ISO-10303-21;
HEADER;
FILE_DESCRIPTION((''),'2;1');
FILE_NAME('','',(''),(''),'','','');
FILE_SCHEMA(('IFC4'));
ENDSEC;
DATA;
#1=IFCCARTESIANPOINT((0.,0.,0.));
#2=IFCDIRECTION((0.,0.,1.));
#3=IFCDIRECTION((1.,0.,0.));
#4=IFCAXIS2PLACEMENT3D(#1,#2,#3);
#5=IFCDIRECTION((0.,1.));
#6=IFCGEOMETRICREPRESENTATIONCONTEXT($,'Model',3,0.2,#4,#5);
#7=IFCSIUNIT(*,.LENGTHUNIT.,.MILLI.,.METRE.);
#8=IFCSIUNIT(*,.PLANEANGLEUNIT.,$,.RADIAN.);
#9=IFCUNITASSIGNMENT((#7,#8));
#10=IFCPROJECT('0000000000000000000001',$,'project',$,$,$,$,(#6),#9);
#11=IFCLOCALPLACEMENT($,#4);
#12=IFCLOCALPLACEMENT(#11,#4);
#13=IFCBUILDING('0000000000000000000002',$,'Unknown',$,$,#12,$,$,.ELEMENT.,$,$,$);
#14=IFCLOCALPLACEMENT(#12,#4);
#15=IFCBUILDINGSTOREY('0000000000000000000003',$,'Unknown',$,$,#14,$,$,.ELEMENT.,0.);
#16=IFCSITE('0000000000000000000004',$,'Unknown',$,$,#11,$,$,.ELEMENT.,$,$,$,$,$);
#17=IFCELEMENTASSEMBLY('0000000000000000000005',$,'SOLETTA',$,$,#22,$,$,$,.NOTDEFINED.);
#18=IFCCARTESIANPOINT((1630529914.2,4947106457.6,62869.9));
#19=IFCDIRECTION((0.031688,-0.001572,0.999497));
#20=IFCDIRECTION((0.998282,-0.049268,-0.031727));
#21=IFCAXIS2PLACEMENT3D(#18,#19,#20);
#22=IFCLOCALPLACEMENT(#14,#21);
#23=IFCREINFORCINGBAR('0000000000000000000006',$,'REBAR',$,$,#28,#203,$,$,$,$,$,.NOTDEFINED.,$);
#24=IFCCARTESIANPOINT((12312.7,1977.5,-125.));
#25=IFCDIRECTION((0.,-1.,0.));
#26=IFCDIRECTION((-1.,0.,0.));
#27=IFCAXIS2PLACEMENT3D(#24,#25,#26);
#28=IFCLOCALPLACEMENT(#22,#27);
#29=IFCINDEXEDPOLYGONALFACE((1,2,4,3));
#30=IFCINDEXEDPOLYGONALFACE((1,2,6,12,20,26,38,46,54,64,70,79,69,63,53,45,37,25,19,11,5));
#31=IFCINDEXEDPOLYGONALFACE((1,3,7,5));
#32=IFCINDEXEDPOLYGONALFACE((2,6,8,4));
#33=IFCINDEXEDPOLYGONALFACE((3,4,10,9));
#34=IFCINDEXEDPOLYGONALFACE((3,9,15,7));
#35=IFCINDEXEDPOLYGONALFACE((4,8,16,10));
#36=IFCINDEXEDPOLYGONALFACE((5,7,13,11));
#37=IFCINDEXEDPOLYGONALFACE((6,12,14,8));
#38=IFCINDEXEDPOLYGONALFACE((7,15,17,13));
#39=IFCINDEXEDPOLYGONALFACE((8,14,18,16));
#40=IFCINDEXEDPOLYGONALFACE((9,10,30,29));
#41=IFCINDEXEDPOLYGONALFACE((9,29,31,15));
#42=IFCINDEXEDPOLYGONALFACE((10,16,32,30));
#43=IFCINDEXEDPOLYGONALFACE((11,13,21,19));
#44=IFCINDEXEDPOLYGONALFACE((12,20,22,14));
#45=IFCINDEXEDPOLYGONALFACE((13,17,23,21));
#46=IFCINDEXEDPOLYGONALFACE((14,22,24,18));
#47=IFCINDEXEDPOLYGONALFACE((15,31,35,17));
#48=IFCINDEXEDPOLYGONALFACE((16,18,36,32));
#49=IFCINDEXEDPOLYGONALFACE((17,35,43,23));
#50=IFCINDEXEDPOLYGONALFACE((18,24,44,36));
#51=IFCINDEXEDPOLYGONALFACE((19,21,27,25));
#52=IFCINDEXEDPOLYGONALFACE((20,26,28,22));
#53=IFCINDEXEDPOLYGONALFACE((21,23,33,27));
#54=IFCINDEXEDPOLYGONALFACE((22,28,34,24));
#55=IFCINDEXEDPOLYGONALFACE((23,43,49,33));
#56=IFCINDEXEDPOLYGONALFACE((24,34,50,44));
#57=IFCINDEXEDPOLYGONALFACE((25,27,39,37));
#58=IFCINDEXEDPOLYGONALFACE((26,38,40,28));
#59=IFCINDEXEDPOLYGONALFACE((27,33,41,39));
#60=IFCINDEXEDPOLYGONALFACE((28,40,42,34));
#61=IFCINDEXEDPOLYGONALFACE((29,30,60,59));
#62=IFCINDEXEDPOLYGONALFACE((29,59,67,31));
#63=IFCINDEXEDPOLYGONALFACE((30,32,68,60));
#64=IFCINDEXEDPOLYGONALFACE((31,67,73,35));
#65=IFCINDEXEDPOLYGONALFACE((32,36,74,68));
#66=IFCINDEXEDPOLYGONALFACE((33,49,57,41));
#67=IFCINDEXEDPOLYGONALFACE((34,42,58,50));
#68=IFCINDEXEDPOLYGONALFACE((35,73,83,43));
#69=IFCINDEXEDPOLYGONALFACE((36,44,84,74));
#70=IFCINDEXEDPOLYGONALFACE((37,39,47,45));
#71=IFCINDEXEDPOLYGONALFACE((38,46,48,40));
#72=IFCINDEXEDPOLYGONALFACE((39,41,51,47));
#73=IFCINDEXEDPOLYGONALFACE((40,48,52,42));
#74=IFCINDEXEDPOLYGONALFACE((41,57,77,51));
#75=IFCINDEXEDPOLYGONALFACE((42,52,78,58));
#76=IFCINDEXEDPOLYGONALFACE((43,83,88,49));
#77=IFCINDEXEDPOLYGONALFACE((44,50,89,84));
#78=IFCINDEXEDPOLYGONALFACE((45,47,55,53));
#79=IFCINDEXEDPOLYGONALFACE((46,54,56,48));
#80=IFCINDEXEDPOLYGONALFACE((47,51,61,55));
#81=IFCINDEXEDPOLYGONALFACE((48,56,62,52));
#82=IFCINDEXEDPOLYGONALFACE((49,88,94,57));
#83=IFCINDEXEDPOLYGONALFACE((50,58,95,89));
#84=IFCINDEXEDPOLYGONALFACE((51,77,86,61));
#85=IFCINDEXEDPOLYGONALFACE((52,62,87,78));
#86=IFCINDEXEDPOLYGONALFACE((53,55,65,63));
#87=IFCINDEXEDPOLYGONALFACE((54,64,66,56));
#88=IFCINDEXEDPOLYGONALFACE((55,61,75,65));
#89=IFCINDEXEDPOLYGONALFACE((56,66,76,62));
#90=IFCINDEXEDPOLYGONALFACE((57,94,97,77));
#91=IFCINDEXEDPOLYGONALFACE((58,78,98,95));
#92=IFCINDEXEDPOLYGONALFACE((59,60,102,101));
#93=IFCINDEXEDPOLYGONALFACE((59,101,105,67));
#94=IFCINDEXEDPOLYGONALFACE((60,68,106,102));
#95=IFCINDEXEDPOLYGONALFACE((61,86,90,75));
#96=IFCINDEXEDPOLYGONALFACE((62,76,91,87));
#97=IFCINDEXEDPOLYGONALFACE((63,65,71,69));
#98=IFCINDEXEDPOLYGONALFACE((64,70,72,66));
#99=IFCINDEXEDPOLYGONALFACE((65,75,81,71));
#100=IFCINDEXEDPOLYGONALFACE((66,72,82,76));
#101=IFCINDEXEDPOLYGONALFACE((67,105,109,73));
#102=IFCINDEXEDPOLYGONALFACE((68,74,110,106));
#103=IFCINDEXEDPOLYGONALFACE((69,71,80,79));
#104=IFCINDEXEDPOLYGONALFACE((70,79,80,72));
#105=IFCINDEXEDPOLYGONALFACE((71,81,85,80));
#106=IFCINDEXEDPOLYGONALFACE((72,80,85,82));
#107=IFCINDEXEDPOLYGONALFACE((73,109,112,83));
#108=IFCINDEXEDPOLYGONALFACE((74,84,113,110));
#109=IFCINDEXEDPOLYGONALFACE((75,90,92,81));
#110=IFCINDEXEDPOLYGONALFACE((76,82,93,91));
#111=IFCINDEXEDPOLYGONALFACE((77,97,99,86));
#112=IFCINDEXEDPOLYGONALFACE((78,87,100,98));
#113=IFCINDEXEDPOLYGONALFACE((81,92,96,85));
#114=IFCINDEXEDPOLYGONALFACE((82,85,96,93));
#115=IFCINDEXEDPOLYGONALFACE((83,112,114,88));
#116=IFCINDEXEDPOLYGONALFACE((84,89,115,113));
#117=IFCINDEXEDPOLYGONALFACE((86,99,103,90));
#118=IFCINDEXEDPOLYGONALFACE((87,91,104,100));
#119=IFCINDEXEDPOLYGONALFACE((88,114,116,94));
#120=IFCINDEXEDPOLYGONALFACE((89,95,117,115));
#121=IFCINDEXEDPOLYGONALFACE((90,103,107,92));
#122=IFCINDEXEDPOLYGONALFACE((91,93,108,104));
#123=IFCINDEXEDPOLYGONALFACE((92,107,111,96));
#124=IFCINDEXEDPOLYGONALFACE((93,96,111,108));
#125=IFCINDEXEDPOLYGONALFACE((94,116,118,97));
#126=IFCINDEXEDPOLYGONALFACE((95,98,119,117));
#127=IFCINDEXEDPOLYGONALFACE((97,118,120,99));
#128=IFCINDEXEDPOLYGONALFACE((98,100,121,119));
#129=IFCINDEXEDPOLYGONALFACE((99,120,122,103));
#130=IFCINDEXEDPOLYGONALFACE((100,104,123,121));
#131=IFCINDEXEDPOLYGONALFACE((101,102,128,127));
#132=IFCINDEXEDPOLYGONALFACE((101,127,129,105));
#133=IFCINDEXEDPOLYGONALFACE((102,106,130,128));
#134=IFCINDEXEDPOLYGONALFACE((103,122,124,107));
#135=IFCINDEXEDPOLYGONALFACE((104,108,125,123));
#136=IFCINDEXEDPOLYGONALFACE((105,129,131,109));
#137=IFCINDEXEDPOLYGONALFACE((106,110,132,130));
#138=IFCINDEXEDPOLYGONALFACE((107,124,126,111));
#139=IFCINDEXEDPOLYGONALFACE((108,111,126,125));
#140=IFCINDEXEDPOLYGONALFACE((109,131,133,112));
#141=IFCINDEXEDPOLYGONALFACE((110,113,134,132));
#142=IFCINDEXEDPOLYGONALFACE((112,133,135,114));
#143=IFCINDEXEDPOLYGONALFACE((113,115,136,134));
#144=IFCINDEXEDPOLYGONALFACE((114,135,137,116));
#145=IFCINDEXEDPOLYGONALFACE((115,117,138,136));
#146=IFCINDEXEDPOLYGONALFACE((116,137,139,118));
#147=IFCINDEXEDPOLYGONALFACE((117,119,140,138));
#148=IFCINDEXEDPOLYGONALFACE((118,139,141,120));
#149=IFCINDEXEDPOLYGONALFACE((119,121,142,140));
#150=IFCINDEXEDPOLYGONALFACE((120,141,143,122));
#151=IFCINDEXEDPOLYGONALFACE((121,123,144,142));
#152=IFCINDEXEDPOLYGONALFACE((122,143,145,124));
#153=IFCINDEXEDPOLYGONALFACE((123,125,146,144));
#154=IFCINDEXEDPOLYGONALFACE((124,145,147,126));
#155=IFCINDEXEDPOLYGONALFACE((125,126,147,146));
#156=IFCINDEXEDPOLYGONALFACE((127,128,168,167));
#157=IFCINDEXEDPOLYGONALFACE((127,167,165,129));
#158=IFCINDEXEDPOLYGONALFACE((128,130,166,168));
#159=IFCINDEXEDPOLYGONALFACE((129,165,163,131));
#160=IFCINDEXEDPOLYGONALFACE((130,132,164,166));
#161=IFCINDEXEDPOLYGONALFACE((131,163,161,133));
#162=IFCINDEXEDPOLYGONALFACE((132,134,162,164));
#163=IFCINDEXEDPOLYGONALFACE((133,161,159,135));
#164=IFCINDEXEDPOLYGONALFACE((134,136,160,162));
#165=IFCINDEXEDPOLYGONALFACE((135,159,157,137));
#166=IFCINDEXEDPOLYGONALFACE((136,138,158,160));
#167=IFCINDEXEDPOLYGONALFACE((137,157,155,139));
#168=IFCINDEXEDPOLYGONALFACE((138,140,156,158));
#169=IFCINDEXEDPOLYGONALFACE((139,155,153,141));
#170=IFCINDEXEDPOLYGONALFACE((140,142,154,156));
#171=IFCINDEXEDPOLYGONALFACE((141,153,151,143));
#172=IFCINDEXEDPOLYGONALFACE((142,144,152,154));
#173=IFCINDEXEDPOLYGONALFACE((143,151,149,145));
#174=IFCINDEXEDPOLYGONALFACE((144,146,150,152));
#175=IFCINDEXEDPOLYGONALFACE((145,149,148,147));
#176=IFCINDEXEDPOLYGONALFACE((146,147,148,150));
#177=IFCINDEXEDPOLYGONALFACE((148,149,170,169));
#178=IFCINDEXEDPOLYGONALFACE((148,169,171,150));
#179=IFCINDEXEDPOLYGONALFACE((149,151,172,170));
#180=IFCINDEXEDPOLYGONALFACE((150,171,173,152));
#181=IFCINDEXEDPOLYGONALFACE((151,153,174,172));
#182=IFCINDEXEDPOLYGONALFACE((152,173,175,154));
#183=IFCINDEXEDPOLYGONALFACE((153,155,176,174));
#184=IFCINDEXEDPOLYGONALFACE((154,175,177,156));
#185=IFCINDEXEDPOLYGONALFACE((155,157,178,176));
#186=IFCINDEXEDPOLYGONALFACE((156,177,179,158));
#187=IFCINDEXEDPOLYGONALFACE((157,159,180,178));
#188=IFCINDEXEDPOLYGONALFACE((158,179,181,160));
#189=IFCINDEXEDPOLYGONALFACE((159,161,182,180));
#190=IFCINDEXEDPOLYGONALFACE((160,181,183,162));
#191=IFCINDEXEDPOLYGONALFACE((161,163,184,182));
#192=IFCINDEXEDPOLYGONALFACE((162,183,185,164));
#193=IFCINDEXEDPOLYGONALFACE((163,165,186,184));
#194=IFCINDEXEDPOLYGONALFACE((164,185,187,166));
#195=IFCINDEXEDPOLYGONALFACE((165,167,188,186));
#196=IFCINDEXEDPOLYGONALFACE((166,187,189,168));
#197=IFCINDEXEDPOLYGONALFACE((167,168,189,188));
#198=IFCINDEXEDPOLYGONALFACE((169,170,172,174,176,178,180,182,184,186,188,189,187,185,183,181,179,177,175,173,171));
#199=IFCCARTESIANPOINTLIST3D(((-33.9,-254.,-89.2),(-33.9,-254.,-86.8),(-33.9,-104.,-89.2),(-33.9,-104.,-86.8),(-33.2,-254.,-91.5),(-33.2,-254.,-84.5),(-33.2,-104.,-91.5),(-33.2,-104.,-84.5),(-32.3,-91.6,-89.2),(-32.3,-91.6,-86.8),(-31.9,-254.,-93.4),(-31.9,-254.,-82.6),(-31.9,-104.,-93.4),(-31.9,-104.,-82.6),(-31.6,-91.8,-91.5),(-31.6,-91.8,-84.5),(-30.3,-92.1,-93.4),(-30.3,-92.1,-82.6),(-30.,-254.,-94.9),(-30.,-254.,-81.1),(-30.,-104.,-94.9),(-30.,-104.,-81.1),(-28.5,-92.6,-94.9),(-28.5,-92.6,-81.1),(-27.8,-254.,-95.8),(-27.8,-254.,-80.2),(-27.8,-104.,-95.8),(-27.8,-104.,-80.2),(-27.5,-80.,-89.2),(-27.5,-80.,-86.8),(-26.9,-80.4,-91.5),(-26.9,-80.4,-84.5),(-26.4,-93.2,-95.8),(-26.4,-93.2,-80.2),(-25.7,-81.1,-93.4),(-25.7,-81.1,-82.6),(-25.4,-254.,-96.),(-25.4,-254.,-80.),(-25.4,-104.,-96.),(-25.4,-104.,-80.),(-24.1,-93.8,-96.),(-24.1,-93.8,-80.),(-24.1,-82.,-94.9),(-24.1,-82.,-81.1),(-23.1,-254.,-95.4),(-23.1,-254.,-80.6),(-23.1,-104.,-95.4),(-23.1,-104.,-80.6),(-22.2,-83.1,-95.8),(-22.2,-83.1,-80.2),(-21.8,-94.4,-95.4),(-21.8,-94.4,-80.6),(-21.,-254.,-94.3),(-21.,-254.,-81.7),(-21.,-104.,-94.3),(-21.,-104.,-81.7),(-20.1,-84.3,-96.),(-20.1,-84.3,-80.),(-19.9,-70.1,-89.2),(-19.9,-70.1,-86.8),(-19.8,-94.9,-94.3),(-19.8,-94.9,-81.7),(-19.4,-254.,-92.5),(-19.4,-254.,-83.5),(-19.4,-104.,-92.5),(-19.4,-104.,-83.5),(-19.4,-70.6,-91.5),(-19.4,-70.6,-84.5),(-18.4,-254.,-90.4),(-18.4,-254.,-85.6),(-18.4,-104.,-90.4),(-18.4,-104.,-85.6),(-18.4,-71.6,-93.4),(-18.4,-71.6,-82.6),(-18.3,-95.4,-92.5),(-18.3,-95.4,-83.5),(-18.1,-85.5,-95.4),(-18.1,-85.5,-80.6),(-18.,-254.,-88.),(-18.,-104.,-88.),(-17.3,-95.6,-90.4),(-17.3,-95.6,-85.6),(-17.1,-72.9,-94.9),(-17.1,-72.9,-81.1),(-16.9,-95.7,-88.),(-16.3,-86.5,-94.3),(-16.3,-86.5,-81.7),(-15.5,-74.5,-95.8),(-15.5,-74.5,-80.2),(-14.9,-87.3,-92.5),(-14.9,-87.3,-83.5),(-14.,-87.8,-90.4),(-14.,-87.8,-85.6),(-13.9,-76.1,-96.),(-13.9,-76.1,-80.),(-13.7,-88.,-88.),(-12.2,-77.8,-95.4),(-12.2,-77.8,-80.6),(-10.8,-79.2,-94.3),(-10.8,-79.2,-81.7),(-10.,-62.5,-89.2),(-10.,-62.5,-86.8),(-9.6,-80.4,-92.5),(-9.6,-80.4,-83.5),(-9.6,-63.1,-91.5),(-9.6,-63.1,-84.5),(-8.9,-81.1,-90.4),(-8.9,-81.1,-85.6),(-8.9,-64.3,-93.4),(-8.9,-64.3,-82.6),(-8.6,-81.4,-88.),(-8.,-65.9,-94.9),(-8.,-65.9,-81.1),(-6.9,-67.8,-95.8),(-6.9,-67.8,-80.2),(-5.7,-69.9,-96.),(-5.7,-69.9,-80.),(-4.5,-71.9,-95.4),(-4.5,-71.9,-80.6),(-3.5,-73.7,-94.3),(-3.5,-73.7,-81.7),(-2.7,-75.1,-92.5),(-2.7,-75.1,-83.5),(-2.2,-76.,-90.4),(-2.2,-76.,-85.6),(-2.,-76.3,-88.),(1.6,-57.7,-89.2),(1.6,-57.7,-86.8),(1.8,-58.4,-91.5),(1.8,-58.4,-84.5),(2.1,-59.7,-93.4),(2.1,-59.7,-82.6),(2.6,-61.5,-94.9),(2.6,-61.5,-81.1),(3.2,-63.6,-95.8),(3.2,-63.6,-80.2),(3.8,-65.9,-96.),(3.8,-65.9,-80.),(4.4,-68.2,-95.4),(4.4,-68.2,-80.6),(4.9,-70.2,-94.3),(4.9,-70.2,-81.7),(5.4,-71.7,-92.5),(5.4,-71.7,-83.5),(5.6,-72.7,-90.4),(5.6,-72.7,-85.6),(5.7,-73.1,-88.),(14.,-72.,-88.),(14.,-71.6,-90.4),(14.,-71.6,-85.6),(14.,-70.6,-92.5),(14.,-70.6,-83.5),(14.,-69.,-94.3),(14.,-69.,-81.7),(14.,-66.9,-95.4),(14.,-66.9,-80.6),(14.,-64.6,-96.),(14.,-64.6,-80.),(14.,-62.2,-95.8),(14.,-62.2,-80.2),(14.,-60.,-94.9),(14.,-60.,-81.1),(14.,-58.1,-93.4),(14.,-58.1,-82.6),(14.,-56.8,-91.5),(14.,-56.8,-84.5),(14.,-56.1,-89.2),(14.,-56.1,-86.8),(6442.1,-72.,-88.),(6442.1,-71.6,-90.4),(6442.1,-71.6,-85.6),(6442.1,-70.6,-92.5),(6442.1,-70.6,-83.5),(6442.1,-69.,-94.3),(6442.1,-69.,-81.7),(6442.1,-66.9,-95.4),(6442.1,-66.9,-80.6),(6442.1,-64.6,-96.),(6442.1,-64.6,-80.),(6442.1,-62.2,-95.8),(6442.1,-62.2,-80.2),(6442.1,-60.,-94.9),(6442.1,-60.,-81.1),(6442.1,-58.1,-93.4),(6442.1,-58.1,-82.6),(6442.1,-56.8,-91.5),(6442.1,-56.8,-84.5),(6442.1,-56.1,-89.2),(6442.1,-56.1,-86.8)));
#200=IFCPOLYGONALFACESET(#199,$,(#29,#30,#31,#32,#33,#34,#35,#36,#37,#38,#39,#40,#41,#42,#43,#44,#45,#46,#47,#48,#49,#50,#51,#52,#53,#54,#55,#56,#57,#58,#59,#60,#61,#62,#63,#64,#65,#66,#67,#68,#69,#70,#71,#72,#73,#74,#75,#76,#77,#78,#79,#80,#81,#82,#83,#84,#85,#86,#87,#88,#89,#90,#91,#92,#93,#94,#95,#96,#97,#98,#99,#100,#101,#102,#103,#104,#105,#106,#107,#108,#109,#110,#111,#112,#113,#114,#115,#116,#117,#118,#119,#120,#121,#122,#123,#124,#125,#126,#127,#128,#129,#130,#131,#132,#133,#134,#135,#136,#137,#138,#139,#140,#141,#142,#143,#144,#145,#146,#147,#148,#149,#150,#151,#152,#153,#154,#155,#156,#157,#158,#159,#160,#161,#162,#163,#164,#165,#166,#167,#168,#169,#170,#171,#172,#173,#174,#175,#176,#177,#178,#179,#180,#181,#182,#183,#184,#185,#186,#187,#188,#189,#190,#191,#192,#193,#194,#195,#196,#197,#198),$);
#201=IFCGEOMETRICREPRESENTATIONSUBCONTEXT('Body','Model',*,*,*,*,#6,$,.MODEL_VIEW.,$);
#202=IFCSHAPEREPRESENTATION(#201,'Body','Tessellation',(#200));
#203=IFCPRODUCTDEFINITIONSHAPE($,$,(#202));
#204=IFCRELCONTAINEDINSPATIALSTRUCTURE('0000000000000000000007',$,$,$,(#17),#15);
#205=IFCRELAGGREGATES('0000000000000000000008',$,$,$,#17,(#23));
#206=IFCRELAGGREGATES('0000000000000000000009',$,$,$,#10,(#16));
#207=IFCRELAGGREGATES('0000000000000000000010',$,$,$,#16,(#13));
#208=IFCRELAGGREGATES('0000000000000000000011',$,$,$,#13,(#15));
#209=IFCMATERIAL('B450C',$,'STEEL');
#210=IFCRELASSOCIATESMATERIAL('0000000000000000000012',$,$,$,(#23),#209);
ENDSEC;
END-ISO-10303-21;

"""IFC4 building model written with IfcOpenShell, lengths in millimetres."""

from ifc_helpers import new_model, entity, si_unit, direction, frame, origin_with_axes, place, context, subcontext, project, spatial, material, element, aggregate, save


model = new_model("IFC4")

# Units and contexts
model_context = context("Model", 3, precision=0.2, world=origin_with_axes(), true_north=direction((0.0, 1.0)))
body_context = subcontext(model_context, "Body", "Model", "MODEL_VIEW")
ifc_project = project(units=[si_unit("LENGTHUNIT", "METRE", prefix="MILLI"), si_unit("PLANEANGLEUNIT", "RADIAN")], contexts=[model_context])

# Site, building, storey
site_placement = place(None, origin_with_axes())
site = spatial("IfcSite", under=ifc_project, at=site_placement, Name="Unknown", CompositionType="ELEMENT")
building_placement = place(site_placement, origin_with_axes())
building = spatial("IfcBuilding", under=site, at=building_placement, Name="Unknown", CompositionType="ELEMENT")
storey_placement = place(building_placement, origin_with_axes())
storey = spatial("IfcBuildingStorey", under=building, at=storey_placement, Name="Unknown", CompositionType="ELEMENT", Elevation=0.0)

# Shared definitions
ifc_material = material(Name="B450C", Category="STEEL")

# Element assembly, reinforcing bar
assembly_1_placement = place(storey_placement, frame((1630529914.2, 4947106457.6, 62869.9), z_axis=(0.031688, -0.001572, 0.999497), x_axis=(0.998282, -0.049268, -0.031727)))
assembly_1 = element("IfcElementAssembly", 1, at=assembly_1_placement, inside=storey, Name="SOLETTA", PredefinedType="NOTDEFINED")
reinforcing_bar_1_placement = place(assembly_1_placement, frame((12312.7, 1977.5, -125.0), z_axis=(0.0, -1.0, 0.0), x_axis=(-1.0, 0.0, 0.0)))
reinforcing_bar_1 = element("IfcReinforcingBar", 2, at=reinforcing_bar_1_placement, material=ifc_material, Name="REBAR", PredefinedType="NOTDEFINED", context=body_context, shape_type="AdvancedSweptSolid", body=[
    entity("IfcSweptDiskSolid", entity("IfcIndexedPolyCurve", entity("IfcCartesianPointList3D", [[-26.0, -254.0, -88.0], [-26.0, -104.0, -88.0], [-14.3, -75.7, -88.0], [14.0, -64.0, -88.0], [6442.1, -64.0, -88.0]]), [entity("IfcLineIndex", [1, 2]), entity("IfcArcIndex", [2, 3, 4]), entity("IfcLineIndex", [4, 5])]), 8.0),
])
aggregate(assembly_1, [reinforcing_bar_1])

save(model, "model.ifc")
